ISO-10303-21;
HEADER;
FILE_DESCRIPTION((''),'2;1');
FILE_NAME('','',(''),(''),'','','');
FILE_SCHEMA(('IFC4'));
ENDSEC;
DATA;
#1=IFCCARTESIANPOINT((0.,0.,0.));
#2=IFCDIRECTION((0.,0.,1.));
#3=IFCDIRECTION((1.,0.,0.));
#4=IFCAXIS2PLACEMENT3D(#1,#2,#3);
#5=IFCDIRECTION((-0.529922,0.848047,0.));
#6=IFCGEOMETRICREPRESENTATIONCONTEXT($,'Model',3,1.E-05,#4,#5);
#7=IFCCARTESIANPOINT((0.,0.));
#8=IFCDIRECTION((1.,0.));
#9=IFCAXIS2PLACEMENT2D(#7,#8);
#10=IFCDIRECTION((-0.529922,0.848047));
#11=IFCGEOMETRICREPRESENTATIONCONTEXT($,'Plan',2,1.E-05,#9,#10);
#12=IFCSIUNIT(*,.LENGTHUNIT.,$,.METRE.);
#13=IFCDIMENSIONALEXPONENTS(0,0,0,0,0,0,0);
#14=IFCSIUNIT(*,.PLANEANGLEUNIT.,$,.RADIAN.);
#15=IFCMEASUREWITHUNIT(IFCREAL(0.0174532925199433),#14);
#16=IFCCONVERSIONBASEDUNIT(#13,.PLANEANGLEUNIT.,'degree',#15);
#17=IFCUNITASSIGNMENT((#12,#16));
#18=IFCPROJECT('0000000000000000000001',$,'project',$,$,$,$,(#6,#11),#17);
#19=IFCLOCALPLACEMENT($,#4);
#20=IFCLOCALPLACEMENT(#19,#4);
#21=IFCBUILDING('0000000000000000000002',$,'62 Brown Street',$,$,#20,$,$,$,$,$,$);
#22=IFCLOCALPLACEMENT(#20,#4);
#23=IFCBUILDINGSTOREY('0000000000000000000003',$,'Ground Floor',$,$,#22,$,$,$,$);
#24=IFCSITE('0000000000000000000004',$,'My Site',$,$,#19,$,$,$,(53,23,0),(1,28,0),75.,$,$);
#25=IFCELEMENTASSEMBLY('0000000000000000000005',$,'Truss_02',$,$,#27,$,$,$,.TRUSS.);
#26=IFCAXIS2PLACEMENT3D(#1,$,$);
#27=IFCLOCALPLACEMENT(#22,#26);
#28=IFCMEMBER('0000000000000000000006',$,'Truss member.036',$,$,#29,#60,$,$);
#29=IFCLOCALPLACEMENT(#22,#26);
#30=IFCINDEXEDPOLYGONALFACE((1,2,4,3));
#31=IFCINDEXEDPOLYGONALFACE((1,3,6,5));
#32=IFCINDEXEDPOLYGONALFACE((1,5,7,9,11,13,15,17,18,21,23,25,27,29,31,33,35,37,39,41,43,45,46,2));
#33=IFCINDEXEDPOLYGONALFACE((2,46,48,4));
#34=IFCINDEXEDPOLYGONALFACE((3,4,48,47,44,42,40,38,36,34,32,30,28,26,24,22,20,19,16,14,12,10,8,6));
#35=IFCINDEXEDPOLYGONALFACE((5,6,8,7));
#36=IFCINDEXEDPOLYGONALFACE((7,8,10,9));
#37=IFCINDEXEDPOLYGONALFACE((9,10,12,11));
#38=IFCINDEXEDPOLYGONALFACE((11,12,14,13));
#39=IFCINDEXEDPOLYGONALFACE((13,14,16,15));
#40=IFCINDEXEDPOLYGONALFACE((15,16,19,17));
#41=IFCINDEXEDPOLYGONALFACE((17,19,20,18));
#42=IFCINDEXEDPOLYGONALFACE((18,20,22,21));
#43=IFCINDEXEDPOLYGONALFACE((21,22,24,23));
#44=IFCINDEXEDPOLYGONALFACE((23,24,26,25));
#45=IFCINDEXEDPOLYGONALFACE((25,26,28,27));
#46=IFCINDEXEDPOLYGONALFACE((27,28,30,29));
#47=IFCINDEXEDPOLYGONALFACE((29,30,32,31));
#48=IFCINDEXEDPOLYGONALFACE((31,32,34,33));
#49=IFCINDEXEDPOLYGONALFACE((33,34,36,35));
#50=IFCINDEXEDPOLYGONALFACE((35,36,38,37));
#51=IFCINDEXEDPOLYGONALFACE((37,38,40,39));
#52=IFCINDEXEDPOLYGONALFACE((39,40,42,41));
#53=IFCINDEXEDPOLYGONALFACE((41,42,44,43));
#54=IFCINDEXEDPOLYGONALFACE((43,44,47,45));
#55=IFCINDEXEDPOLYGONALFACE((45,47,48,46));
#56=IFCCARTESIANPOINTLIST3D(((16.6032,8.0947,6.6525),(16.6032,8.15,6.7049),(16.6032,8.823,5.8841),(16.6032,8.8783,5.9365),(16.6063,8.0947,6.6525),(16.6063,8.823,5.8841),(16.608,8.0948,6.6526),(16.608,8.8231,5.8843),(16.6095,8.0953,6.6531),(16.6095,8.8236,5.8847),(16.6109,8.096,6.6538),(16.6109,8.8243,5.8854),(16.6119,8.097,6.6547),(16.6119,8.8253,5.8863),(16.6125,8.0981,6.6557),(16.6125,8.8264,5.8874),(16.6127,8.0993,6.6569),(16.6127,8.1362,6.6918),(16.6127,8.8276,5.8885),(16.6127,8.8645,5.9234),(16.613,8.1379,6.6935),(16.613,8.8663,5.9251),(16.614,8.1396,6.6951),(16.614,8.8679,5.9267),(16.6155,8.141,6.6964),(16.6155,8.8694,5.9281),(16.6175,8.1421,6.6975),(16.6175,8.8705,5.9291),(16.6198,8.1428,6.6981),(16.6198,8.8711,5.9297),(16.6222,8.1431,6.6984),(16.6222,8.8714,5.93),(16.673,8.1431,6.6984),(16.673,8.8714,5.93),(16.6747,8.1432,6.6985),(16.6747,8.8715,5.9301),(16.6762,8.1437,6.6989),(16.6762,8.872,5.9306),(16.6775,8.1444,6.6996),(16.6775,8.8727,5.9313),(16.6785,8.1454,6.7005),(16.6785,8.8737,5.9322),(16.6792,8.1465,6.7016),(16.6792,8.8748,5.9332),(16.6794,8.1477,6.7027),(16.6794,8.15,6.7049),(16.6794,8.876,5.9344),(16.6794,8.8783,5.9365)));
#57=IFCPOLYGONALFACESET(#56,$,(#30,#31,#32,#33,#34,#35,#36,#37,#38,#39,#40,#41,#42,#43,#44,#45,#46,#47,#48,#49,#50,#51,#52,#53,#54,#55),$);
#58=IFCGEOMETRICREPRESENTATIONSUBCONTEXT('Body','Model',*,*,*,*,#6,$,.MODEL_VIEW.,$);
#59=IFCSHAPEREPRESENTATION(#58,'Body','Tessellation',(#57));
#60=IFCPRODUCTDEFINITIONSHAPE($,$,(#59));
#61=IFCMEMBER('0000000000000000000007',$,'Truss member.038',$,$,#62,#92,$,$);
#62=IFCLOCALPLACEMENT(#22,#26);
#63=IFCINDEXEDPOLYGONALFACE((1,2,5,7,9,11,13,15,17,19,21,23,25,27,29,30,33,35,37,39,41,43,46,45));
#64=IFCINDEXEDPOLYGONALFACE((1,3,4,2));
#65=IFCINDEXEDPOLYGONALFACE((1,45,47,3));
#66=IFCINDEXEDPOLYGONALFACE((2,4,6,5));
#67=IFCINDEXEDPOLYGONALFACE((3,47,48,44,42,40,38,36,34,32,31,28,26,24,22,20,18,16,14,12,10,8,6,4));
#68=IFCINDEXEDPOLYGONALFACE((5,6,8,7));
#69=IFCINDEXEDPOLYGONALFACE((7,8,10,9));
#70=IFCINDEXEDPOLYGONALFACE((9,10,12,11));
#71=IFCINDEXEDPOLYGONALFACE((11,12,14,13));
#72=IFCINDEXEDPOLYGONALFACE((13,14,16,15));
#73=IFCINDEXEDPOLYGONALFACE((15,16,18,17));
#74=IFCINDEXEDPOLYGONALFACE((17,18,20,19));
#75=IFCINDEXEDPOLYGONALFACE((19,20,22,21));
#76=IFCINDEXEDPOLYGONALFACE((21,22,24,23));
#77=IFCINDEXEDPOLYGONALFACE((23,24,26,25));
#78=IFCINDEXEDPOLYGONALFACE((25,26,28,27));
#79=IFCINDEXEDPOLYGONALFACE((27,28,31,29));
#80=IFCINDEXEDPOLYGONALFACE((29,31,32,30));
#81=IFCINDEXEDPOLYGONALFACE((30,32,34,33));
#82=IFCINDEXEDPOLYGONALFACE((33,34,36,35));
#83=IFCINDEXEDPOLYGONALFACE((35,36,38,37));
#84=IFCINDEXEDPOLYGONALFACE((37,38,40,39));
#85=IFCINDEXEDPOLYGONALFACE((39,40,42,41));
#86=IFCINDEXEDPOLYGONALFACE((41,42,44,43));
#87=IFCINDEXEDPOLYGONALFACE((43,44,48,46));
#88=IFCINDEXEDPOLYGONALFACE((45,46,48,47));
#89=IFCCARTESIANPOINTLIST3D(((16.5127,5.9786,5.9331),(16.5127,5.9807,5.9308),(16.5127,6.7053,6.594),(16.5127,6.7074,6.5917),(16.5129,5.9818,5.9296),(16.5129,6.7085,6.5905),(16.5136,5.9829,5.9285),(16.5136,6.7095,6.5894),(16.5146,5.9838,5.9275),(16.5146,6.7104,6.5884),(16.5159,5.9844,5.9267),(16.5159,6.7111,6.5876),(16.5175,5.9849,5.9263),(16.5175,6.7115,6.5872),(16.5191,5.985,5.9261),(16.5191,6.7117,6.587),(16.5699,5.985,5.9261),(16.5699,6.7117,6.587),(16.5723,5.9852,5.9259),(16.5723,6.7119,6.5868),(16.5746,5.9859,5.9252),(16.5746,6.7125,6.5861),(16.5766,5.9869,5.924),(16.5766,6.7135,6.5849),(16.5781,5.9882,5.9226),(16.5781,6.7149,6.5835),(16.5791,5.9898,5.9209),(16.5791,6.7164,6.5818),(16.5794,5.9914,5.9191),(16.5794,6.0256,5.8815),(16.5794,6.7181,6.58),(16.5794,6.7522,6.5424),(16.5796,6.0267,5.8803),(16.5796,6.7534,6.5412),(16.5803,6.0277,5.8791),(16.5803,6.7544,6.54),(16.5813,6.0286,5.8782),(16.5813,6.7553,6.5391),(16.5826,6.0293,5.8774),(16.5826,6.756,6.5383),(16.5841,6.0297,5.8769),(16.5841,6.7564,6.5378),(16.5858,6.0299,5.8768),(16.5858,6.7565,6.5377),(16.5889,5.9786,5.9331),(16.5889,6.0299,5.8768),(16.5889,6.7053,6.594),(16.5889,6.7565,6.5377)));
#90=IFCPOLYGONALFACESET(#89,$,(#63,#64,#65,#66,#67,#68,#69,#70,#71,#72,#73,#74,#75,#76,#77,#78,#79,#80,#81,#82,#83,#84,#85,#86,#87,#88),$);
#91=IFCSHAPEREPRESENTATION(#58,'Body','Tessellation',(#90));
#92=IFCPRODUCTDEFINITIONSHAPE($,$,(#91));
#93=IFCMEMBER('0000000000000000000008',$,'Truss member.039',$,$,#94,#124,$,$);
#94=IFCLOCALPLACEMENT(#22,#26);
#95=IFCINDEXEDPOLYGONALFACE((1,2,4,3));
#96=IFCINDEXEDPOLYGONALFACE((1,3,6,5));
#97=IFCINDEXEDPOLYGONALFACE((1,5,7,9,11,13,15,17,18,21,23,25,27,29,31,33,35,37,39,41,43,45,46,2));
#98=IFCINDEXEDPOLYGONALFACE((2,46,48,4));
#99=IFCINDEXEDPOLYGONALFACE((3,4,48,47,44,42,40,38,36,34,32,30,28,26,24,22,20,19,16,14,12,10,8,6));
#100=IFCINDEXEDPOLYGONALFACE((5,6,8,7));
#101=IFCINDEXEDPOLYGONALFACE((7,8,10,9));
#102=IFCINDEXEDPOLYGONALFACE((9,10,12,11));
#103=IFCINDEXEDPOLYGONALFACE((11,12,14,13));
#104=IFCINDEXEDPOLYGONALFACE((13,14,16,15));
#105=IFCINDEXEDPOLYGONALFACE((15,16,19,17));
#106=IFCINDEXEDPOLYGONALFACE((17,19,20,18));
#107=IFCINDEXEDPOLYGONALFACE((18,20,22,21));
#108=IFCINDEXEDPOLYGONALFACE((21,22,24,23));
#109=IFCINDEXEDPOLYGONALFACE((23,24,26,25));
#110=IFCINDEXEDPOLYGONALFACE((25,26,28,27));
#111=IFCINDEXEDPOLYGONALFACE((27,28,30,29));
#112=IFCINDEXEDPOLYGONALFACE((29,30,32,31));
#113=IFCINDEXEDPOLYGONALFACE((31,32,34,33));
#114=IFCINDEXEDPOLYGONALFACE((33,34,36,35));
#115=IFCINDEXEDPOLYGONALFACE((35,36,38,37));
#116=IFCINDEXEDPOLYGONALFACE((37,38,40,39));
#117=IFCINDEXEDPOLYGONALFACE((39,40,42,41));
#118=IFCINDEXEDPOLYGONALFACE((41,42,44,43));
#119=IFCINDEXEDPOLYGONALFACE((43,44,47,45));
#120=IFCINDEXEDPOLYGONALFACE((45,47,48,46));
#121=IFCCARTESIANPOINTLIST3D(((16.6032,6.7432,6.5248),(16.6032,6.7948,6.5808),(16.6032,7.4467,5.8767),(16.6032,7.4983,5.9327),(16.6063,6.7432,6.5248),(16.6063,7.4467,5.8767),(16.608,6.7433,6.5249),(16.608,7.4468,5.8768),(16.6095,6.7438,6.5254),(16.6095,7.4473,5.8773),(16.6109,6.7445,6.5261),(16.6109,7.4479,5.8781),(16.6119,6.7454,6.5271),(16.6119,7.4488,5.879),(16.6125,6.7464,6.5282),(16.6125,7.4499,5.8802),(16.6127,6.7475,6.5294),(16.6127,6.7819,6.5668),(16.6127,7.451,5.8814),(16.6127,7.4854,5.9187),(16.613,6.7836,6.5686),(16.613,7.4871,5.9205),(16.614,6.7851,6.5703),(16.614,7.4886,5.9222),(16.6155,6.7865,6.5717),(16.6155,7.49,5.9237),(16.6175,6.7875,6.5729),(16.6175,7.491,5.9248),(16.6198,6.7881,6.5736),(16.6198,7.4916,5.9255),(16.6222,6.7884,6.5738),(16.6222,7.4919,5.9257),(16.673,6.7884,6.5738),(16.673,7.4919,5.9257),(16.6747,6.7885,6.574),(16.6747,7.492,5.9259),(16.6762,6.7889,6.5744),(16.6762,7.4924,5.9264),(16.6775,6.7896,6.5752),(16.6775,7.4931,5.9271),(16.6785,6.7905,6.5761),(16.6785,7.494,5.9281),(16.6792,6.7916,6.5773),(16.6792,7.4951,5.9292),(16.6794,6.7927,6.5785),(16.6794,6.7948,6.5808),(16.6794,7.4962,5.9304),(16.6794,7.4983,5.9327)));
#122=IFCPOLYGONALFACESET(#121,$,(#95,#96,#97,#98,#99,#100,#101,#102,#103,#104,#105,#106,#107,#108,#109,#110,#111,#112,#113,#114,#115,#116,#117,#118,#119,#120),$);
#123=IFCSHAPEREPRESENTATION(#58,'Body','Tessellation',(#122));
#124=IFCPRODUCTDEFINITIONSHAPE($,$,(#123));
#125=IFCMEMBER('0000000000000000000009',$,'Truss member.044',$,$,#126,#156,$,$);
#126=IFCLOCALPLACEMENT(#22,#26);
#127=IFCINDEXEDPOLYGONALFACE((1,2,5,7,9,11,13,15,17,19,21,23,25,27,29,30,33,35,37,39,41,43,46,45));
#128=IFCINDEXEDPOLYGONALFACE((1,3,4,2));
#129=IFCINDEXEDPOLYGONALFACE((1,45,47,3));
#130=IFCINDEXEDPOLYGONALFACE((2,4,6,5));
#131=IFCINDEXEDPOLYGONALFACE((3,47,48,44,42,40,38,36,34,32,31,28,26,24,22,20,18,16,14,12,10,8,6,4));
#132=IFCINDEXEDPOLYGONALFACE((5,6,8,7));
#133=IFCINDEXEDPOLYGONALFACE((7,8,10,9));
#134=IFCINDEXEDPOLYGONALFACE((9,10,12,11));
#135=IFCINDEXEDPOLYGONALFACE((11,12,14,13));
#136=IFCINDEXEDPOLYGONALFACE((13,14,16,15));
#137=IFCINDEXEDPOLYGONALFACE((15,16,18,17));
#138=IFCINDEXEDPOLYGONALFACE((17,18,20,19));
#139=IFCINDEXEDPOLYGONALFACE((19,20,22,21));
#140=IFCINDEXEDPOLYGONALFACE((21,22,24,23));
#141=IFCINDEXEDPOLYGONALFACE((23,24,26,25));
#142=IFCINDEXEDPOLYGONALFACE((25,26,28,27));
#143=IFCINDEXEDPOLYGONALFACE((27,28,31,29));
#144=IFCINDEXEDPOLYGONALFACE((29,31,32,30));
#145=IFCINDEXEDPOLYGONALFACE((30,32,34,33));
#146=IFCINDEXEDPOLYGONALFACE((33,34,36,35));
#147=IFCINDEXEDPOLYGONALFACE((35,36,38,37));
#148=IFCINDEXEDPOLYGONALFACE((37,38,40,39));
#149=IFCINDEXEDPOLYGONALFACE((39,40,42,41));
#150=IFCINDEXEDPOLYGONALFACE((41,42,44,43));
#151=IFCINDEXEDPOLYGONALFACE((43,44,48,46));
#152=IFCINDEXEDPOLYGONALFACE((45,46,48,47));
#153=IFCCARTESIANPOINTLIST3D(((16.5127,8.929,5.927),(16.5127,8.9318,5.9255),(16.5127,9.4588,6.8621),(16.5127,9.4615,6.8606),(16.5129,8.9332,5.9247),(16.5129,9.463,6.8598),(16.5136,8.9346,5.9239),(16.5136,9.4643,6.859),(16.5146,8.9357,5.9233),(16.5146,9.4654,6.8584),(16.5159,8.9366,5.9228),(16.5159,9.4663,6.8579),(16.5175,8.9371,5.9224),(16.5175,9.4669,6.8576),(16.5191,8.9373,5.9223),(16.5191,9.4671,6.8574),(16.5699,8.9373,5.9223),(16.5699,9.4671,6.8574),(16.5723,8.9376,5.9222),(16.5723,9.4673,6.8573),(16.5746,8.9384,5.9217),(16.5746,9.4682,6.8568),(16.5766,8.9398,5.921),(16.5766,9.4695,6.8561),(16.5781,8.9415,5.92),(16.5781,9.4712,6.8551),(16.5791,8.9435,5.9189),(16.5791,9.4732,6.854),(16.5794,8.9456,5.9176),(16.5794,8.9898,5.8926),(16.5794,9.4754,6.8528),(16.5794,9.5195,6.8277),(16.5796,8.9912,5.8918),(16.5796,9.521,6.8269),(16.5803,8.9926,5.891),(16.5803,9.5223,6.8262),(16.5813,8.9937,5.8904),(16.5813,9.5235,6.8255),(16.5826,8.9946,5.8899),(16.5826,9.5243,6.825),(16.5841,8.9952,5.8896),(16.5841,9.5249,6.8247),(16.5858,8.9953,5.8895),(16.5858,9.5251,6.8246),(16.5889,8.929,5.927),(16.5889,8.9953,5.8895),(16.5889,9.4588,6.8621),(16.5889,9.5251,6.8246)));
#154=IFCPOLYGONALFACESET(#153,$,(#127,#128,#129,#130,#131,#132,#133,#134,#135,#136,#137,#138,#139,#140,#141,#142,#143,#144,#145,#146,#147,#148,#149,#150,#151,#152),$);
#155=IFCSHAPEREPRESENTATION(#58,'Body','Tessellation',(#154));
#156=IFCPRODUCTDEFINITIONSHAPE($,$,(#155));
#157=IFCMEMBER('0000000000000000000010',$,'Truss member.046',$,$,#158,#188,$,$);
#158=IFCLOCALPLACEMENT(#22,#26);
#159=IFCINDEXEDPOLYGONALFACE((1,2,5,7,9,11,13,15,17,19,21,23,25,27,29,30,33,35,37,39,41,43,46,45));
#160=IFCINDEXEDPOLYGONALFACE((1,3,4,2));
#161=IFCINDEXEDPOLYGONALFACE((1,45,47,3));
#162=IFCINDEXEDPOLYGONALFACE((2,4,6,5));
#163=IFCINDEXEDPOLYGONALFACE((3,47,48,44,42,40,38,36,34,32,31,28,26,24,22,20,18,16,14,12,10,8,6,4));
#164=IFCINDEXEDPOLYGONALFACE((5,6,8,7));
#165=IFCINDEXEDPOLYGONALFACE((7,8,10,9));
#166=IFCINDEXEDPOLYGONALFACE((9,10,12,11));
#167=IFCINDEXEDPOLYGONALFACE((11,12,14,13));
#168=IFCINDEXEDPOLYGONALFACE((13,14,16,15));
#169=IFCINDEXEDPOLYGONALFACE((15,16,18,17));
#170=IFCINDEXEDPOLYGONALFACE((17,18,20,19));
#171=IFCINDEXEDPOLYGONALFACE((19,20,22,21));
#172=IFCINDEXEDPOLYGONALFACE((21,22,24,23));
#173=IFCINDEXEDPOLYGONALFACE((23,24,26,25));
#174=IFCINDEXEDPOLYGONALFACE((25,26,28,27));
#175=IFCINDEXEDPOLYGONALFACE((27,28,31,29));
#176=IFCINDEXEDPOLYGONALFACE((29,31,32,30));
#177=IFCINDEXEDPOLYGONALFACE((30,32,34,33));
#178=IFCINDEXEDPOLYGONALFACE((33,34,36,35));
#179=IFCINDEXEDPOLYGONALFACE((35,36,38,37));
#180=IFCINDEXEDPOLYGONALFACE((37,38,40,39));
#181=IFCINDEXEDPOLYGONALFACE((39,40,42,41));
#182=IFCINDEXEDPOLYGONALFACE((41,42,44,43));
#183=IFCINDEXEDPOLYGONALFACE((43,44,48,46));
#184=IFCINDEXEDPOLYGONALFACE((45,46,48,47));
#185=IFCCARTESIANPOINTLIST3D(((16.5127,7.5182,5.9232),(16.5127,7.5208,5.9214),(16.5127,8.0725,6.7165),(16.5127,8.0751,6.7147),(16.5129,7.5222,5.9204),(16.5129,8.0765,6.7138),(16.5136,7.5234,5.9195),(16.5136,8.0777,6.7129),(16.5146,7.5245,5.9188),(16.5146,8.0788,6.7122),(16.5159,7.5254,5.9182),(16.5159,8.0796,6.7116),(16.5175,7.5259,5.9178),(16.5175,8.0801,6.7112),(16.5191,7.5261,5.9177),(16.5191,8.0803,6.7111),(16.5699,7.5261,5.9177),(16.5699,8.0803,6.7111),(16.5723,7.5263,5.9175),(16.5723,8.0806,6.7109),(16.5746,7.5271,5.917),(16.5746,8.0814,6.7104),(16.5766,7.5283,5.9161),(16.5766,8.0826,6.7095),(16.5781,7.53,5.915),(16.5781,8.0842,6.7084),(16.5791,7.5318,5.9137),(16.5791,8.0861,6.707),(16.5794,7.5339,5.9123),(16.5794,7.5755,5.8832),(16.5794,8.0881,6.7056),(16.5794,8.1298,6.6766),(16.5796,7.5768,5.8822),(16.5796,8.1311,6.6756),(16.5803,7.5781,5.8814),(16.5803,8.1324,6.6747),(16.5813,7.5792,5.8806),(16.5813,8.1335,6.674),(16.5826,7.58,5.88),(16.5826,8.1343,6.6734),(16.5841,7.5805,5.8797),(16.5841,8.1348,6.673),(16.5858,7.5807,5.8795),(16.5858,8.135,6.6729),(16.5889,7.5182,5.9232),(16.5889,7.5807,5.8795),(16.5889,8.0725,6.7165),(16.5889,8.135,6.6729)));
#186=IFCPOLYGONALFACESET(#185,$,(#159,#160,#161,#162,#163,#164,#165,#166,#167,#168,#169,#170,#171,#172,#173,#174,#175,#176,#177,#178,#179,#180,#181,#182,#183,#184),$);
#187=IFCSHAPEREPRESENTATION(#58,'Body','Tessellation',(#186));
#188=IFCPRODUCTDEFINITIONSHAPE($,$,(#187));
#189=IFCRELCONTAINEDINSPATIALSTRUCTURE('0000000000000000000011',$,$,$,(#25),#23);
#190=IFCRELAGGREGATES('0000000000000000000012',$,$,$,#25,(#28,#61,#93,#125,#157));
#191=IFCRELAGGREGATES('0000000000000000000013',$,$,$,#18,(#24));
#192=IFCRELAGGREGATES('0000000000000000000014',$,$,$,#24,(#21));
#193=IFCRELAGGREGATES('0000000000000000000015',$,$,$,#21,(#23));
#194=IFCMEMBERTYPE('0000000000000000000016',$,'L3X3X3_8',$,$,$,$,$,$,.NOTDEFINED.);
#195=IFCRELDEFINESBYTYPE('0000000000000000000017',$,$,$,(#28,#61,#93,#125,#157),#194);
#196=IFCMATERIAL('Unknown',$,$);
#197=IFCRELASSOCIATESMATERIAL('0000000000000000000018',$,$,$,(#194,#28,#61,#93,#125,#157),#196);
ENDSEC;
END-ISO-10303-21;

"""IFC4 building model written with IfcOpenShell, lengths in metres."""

from ifc_helpers import new_model, entity, si_unit, converted_unit, direction, frame, origin_with_axes, origin_2d_with_axis, place, context, subcontext, project, spatial, l_section, extrude, material, material_profile, profile_set, profile_usage, type_object, element, aggregate, save


model = new_model("IFC4")

# Units and contexts
model_context = context("Model", 3, precision=1e-05, world=origin_with_axes(), true_north=direction((-0.529922, 0.848047, 0.0)))
plan_context = context("Plan", 2, precision=1e-05, world=origin_2d_with_axis(), true_north=direction((-0.529922, 0.848047)))
body_context_1 = subcontext(model_context, "Body", "Model", "MODEL_VIEW")
ifc_project = project(units=[si_unit("LENGTHUNIT", "METRE"), converted_unit("PLANEANGLEUNIT", "degree", entity("IfcReal", 0.0174532925199433), si_unit("PLANEANGLEUNIT", "RADIAN"), dimensions=[0, 0, 0, 0, 0, 0, 0])], contexts=[model_context, plan_context])

# Site, building, storey
site_placement = place(None, origin_with_axes())
site = spatial("IfcSite", under=ifc_project, at=site_placement, Name="My Site", RefLatitude=(53, 23, 0), RefLongitude=(1, 28, 0), RefElevation=75.0)
building_placement = place(site_placement, origin_with_axes())
building = spatial("IfcBuilding", under=site, at=building_placement, Name="62 Brown Street")
storey_placement = place(building_placement, origin_with_axes())
storey = spatial("IfcBuildingStorey", under=building, at=storey_placement, Name="Ground Floor")

# Element assembly, members
ifc_material_1 = material(Name="Unknown")
ifc_material_profile_1 = material_profile(ifc_material_1, l_section(Depth=0.0762, Width=0.0762, Thickness=0.0095, FilletRadius=0.0095, EdgeRadius=0.0064))
ifc_profile_set_1 = profile_set([ifc_material_profile_1])
member_type_1 = type_object("IfcMemberType", Name="L3X3X3_8", PredefinedType="NOTDEFINED", material=ifc_profile_set_1)
assembly_1_placement = place(storey_placement, frame((16.6032, 10.4288, 6.9738), z_axis=(0.0, 0.0, 1.0), x_axis=(1.0, 0.0, 0.0)))
assembly_1 = element("IfcElementAssembly", 1, at=assembly_1_placement, inside=storey, Name="Truss_02", PredefinedType="TRUSS")
ifc_profile_usage_1 = profile_usage(ifc_profile_set_1, cardinal=5)
member_1_placement = place(assembly_1_placement, frame((0.0381, -2.3065, -0.2951), z_axis=(-0.000001, 0.687927, -0.72578), x_axis=(1.0, 0.0, 0.0)))
member_1 = element("IfcMember", 2, at=member_1_placement, type_object=member_type_1, material=ifc_profile_usage_1, Name="Truss member.036", context=body_context_1, shape_type="SweptSolid", body=[
    extrude(l_section(Depth=0.0762, Width=0.0762, Thickness=0.0095, FilletRadius=0.0095, EdgeRadius=0.0064), origin_with_axes(), (0.0, 0.0, 1.0), 1.0587),
])
ifc_profile_usage_2 = profile_usage(ifc_profile_set_1, cardinal=5)
member_2_placement = place(assembly_1_placement, frame((-0.0524, -3.6979, -0.4079), z_axis=(0.000001, -0.739785, -0.672843), x_axis=(-1.0, -0.000001, 0.0)))
member_2 = element("IfcMember", 3, at=member_2_placement, type_object=member_type_1, material=ifc_profile_usage_2, Name="Truss member.038", context=body_context_1, shape_type="SweptSolid", body=[
    extrude(l_section(Depth=0.0762, Width=0.0762, Thickness=0.0095, FilletRadius=0.0095, EdgeRadius=0.0064), origin_with_axes(), (0.0, 0.0, 1.0), 0.9823),
])
ifc_profile_usage_3 = profile_usage(ifc_profile_set_1, cardinal=5)
member_3_placement = place(assembly_1_placement, frame((0.0381, -3.6598, -0.421), z_axis=(-0.000001, 0.735484, -0.677542), x_axis=(1.0, 0.000001, 0.0)))
member_3 = element("IfcMember", 4, at=member_3_placement, type_object=member_type_1, material=ifc_profile_usage_3, Name="Truss member.039", context=body_context_1, shape_type="SweptSolid", body=[
    extrude(l_section(Depth=0.0762, Width=0.0762, Thickness=0.0095, FilletRadius=0.0095, EdgeRadius=0.0064), origin_with_axes(), (0.0, 0.0, 1.0), 0.9565),
])
ifc_profile_usage_4 = profile_usage(ifc_profile_set_1, cardinal=5)
member_4_placement = place(assembly_1_placement, frame((-0.0524, -0.9369, -0.1304), z_axis=(0.0, -0.492899, -0.870086), x_axis=(-1.0, 0.0, 0.0)))
member_4 = element("IfcMember", 5, at=member_4_placement, type_object=member_type_1, material=ifc_profile_usage_4, Name="Truss member.044", context=body_context_1, shape_type="SweptSolid", body=[
    extrude(l_section(Depth=0.0762, Width=0.0762, Thickness=0.0095, FilletRadius=0.0095, EdgeRadius=0.0064), origin_with_axes(), (0.0, 0.0, 1.0), 1.0747),
])
ifc_profile_usage_5 = profile_usage(ifc_profile_set_1, cardinal=5)
member_5_placement = place(assembly_1_placement, frame((-0.0524, -2.325, -0.279), z_axis=(0.000001, -0.572709, -0.819759), x_axis=(-1.0, -0.000001, 0.0)))
member_5 = element("IfcMember", 6, at=member_5_placement, type_object=member_type_1, material=ifc_profile_usage_5, Name="Truss member.046", context=body_context_1, shape_type="SweptSolid", body=[
    extrude(l_section(Depth=0.0762, Width=0.0762, Thickness=0.0095, FilletRadius=0.0095, EdgeRadius=0.0064), origin_with_axes(), (0.0, 0.0, 1.0), 0.9678),
])

aggregate(assembly_1, [member_1, member_2, member_3, member_4, member_5])

save(model, "model.ifc")
